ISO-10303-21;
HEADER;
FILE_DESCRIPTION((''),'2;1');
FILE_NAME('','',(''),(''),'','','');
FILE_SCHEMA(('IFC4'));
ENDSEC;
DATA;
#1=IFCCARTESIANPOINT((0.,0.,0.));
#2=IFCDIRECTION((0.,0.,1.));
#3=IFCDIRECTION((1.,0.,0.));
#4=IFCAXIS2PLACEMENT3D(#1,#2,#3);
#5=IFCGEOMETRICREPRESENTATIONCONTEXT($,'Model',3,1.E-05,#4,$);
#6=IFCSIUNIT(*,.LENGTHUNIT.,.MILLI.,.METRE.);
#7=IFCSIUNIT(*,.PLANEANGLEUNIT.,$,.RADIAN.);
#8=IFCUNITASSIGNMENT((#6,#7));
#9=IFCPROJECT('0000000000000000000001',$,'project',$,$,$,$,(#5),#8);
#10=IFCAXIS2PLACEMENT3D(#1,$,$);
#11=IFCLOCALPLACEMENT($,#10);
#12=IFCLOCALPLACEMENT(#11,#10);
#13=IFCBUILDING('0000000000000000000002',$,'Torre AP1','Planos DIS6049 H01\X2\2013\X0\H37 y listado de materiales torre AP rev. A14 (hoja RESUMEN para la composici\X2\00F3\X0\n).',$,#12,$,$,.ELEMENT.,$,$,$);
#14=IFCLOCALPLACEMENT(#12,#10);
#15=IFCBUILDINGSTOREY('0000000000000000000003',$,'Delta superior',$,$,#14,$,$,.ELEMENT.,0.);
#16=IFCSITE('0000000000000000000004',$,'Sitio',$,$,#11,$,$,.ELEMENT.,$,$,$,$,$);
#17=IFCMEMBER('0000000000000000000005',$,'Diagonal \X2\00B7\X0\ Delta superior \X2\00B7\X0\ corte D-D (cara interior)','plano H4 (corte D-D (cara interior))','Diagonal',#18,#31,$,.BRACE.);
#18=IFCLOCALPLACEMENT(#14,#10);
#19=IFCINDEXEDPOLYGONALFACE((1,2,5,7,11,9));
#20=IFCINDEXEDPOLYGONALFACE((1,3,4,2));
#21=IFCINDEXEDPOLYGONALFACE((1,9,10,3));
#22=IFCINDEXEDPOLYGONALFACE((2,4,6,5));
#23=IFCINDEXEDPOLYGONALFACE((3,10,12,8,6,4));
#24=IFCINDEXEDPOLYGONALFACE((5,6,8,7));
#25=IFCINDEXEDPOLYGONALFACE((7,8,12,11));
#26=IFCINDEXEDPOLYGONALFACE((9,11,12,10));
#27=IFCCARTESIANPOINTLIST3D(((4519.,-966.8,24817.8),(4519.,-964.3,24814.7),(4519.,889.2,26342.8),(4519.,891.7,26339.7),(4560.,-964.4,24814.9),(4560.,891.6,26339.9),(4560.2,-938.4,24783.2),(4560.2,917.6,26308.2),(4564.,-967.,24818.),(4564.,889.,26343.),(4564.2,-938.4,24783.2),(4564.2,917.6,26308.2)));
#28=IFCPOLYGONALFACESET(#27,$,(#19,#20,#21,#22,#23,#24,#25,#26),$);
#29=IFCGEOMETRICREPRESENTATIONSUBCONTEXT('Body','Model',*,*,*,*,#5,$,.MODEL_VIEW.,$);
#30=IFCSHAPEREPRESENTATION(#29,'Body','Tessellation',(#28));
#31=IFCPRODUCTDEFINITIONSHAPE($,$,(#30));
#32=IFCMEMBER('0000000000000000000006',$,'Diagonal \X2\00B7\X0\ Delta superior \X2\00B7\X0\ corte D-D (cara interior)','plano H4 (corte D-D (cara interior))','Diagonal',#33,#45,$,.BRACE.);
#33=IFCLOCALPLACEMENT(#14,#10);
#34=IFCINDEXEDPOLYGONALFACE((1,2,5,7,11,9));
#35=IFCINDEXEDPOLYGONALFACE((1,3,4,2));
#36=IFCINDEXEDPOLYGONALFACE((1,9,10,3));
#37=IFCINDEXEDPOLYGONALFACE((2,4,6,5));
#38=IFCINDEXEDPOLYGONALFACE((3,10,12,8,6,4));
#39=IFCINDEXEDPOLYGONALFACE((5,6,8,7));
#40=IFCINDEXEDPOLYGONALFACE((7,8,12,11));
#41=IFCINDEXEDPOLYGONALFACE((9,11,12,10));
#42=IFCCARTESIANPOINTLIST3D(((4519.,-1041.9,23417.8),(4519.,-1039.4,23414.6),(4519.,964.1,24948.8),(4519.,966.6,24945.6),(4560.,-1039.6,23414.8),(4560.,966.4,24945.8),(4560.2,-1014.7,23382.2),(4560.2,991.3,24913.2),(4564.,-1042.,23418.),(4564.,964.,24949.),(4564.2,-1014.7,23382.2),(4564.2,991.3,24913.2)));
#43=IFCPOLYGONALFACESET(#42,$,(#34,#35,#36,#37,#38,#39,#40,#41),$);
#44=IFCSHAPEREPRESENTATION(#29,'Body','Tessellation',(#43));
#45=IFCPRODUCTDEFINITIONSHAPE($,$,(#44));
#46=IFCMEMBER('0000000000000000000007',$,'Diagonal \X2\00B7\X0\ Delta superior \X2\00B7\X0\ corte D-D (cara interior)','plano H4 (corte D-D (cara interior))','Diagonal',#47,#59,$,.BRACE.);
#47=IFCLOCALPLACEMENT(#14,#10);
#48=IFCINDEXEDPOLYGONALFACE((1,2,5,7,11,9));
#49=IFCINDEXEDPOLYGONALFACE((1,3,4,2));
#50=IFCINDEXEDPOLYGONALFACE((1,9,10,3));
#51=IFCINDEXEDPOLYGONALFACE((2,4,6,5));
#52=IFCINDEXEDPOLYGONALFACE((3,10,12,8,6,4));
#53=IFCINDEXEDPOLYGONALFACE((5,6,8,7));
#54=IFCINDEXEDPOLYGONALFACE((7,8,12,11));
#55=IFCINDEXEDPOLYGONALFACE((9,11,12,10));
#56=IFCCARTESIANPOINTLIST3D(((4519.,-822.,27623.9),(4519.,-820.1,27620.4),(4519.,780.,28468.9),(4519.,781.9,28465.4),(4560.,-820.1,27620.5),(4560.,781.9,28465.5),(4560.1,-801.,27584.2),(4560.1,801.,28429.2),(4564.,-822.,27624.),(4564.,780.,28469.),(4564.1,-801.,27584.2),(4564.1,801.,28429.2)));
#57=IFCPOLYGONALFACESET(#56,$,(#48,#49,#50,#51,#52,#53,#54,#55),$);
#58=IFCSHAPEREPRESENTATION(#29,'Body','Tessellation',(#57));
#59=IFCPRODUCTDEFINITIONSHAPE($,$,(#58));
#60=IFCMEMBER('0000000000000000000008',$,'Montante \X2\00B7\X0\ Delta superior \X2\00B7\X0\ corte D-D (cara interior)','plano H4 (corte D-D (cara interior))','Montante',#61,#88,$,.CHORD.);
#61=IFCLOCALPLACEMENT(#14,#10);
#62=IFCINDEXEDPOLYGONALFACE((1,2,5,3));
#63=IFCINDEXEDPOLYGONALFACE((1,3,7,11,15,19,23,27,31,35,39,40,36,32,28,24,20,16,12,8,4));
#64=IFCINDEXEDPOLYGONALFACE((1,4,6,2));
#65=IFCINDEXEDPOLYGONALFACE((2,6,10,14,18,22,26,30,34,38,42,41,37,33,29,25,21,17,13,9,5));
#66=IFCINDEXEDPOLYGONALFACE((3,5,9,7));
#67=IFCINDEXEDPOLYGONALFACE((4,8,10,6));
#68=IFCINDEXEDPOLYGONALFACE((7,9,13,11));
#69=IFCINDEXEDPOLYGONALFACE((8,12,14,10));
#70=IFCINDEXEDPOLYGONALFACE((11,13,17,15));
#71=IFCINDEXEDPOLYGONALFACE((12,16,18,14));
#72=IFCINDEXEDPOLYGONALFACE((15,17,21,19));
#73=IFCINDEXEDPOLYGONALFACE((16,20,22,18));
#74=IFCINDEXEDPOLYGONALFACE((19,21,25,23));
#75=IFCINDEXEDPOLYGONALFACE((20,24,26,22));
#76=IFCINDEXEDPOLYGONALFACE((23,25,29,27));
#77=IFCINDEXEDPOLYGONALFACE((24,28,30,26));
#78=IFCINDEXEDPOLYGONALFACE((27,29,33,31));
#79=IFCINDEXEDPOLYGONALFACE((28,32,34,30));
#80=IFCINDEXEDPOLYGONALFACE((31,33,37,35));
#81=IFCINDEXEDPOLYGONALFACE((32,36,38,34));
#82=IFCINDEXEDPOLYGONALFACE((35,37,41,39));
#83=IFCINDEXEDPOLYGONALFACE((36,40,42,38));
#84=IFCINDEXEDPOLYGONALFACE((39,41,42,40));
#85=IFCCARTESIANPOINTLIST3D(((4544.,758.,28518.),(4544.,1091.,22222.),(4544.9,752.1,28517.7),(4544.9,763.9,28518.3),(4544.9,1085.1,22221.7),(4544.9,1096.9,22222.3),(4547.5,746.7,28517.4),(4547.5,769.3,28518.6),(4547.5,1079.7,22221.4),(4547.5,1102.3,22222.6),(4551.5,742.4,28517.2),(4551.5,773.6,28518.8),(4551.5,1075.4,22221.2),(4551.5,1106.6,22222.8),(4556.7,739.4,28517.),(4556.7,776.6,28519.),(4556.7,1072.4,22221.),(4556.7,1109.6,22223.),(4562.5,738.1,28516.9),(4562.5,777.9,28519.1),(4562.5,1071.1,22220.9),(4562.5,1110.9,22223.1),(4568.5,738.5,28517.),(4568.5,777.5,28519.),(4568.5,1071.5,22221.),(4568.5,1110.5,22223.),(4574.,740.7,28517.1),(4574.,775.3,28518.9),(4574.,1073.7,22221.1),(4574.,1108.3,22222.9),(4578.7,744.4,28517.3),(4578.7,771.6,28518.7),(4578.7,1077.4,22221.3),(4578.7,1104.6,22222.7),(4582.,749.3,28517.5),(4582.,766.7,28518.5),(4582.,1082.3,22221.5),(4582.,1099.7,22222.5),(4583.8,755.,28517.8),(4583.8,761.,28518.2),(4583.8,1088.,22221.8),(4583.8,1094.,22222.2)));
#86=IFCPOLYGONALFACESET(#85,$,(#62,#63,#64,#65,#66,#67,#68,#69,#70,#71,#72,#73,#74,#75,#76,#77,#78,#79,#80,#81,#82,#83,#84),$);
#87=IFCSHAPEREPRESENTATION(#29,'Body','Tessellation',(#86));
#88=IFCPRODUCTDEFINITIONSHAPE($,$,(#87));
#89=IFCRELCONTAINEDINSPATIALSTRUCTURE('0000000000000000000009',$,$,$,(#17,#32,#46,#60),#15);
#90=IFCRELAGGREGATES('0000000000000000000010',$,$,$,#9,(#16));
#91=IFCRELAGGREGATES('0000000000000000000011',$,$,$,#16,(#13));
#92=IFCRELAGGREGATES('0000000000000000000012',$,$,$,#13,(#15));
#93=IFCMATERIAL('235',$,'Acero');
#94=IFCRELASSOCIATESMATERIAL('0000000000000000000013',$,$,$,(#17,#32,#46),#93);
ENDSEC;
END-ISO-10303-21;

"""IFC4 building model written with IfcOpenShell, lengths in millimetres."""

from ifc_helpers import new_model, si_unit, frame, frame_2d, origin, origin_with_axes, place, context, subcontext, project, spatial, circle, l_section, extrude, material, element, save


model = new_model("IFC4")

# Units and contexts
model_context = context("Model", 3, precision=1e-05, world=origin_with_axes())
body_context = subcontext(model_context, "Body", "Model", "MODEL_VIEW")
ifc_project = project(units=[si_unit("LENGTHUNIT", "METRE", prefix="MILLI"), si_unit("PLANEANGLEUNIT", "RADIAN")], contexts=[model_context])

# Site, building, storey
site_placement = place(None, origin())
site = spatial("IfcSite", under=ifc_project, at=site_placement, Name="Sitio", CompositionType="ELEMENT")
building_placement = place(site_placement, origin())
building = spatial("IfcBuilding", under=site, at=building_placement, Name="Torre AP1", Description="Planos DIS6049 H01–H37 y listado de materiales torre AP rev. A14 (hoja RESUMEN para la composición).", CompositionType="ELEMENT")
storey_placement = place(building_placement, origin())
storey = spatial("IfcBuildingStorey", under=building, at=storey_placement, Name="Delta superior", CompositionType="ELEMENT", Elevation=0.0)

# Members
ifc_material_1 = material(Name="235", Category="Acero")
member_1_placement = place(storey_placement, frame((4564.0, 889.0, 26343.0), z_axis=(0.0, -0.772639, -0.634846), x_axis=(-0.999985, 0.003444, -0.004191)))
element("IfcMember", 1, at=member_1_placement, inside=storey, material=ifc_material_1, Name="Diagonal · Delta superior · corte D-D (cara interior)", Description="plano H4 (corte D-D (cara interior))", ObjectType="Diagonal", PredefinedType="BRACE", context=body_context, shape_type="SweptSolid", body=[
    extrude(l_section(Depth=45.0, Width=45.0, Thickness=4.0, at=frame_2d((22.5, 22.5))), None, (0.0, 0.0, 1.0), 2402.2),
])
member_2_placement = place(storey_placement, frame((4564.0, 964.0, 24949.0), z_axis=(0.0, -0.794931, -0.6067), x_axis=(-0.999987, 0.003145, -0.004121)))
element("IfcMember", 2, at=member_2_placement, inside=storey, material=ifc_material_1, Name="Diagonal · Delta superior · corte D-D (cara interior)", Description="plano H4 (corte D-D (cara interior))", ObjectType="Diagonal", PredefinedType="BRACE", context=body_context, shape_type="SweptSolid", body=[
    extrude(l_section(Depth=45.0, Width=45.0, Thickness=4.0, at=frame_2d((22.5, 22.5))), None, (0.0, 0.0, 1.0), 2523.5),
])
member_3_placement = place(storey_placement, frame((4564.0, 780.0, 28469.0), z_axis=(0.0, -0.884499, -0.466543), x_axis=(-0.999998, 0.001002, -0.001899)))
element("IfcMember", 3, at=member_3_placement, inside=storey, material=ifc_material_1, Name="Diagonal · Delta superior · corte D-D (cara interior)", Description="plano H4 (corte D-D (cara interior))", ObjectType="Diagonal", PredefinedType="BRACE", context=body_context, shape_type="SweptSolid", body=[
    extrude(l_section(Depth=45.0, Width=45.0, Thickness=4.0, at=frame_2d((22.5, 22.5))), None, (0.0, 0.0, 1.0), 1811.2),
])
member_4_placement = place(storey_placement, frame((4564.0, 1091.0, 22222.0), z_axis=(0.0, -0.052817, 0.998604), x_axis=(-1.0, 0.0, 0.0)))
element("IfcMember", 4, at=member_4_placement, inside=storey, Name="Montante · Delta superior · corte D-D (cara interior)", Description="plano H4 (corte D-D (cara interior))", ObjectType="Montante", PredefinedType="CHORD", context=body_context, shape_type="SweptSolid", body=[
    extrude(circle(Radius=20.0), None, (0.0, 0.0, 1.0), 6304.8),
])

save(model, "model.ifc")
